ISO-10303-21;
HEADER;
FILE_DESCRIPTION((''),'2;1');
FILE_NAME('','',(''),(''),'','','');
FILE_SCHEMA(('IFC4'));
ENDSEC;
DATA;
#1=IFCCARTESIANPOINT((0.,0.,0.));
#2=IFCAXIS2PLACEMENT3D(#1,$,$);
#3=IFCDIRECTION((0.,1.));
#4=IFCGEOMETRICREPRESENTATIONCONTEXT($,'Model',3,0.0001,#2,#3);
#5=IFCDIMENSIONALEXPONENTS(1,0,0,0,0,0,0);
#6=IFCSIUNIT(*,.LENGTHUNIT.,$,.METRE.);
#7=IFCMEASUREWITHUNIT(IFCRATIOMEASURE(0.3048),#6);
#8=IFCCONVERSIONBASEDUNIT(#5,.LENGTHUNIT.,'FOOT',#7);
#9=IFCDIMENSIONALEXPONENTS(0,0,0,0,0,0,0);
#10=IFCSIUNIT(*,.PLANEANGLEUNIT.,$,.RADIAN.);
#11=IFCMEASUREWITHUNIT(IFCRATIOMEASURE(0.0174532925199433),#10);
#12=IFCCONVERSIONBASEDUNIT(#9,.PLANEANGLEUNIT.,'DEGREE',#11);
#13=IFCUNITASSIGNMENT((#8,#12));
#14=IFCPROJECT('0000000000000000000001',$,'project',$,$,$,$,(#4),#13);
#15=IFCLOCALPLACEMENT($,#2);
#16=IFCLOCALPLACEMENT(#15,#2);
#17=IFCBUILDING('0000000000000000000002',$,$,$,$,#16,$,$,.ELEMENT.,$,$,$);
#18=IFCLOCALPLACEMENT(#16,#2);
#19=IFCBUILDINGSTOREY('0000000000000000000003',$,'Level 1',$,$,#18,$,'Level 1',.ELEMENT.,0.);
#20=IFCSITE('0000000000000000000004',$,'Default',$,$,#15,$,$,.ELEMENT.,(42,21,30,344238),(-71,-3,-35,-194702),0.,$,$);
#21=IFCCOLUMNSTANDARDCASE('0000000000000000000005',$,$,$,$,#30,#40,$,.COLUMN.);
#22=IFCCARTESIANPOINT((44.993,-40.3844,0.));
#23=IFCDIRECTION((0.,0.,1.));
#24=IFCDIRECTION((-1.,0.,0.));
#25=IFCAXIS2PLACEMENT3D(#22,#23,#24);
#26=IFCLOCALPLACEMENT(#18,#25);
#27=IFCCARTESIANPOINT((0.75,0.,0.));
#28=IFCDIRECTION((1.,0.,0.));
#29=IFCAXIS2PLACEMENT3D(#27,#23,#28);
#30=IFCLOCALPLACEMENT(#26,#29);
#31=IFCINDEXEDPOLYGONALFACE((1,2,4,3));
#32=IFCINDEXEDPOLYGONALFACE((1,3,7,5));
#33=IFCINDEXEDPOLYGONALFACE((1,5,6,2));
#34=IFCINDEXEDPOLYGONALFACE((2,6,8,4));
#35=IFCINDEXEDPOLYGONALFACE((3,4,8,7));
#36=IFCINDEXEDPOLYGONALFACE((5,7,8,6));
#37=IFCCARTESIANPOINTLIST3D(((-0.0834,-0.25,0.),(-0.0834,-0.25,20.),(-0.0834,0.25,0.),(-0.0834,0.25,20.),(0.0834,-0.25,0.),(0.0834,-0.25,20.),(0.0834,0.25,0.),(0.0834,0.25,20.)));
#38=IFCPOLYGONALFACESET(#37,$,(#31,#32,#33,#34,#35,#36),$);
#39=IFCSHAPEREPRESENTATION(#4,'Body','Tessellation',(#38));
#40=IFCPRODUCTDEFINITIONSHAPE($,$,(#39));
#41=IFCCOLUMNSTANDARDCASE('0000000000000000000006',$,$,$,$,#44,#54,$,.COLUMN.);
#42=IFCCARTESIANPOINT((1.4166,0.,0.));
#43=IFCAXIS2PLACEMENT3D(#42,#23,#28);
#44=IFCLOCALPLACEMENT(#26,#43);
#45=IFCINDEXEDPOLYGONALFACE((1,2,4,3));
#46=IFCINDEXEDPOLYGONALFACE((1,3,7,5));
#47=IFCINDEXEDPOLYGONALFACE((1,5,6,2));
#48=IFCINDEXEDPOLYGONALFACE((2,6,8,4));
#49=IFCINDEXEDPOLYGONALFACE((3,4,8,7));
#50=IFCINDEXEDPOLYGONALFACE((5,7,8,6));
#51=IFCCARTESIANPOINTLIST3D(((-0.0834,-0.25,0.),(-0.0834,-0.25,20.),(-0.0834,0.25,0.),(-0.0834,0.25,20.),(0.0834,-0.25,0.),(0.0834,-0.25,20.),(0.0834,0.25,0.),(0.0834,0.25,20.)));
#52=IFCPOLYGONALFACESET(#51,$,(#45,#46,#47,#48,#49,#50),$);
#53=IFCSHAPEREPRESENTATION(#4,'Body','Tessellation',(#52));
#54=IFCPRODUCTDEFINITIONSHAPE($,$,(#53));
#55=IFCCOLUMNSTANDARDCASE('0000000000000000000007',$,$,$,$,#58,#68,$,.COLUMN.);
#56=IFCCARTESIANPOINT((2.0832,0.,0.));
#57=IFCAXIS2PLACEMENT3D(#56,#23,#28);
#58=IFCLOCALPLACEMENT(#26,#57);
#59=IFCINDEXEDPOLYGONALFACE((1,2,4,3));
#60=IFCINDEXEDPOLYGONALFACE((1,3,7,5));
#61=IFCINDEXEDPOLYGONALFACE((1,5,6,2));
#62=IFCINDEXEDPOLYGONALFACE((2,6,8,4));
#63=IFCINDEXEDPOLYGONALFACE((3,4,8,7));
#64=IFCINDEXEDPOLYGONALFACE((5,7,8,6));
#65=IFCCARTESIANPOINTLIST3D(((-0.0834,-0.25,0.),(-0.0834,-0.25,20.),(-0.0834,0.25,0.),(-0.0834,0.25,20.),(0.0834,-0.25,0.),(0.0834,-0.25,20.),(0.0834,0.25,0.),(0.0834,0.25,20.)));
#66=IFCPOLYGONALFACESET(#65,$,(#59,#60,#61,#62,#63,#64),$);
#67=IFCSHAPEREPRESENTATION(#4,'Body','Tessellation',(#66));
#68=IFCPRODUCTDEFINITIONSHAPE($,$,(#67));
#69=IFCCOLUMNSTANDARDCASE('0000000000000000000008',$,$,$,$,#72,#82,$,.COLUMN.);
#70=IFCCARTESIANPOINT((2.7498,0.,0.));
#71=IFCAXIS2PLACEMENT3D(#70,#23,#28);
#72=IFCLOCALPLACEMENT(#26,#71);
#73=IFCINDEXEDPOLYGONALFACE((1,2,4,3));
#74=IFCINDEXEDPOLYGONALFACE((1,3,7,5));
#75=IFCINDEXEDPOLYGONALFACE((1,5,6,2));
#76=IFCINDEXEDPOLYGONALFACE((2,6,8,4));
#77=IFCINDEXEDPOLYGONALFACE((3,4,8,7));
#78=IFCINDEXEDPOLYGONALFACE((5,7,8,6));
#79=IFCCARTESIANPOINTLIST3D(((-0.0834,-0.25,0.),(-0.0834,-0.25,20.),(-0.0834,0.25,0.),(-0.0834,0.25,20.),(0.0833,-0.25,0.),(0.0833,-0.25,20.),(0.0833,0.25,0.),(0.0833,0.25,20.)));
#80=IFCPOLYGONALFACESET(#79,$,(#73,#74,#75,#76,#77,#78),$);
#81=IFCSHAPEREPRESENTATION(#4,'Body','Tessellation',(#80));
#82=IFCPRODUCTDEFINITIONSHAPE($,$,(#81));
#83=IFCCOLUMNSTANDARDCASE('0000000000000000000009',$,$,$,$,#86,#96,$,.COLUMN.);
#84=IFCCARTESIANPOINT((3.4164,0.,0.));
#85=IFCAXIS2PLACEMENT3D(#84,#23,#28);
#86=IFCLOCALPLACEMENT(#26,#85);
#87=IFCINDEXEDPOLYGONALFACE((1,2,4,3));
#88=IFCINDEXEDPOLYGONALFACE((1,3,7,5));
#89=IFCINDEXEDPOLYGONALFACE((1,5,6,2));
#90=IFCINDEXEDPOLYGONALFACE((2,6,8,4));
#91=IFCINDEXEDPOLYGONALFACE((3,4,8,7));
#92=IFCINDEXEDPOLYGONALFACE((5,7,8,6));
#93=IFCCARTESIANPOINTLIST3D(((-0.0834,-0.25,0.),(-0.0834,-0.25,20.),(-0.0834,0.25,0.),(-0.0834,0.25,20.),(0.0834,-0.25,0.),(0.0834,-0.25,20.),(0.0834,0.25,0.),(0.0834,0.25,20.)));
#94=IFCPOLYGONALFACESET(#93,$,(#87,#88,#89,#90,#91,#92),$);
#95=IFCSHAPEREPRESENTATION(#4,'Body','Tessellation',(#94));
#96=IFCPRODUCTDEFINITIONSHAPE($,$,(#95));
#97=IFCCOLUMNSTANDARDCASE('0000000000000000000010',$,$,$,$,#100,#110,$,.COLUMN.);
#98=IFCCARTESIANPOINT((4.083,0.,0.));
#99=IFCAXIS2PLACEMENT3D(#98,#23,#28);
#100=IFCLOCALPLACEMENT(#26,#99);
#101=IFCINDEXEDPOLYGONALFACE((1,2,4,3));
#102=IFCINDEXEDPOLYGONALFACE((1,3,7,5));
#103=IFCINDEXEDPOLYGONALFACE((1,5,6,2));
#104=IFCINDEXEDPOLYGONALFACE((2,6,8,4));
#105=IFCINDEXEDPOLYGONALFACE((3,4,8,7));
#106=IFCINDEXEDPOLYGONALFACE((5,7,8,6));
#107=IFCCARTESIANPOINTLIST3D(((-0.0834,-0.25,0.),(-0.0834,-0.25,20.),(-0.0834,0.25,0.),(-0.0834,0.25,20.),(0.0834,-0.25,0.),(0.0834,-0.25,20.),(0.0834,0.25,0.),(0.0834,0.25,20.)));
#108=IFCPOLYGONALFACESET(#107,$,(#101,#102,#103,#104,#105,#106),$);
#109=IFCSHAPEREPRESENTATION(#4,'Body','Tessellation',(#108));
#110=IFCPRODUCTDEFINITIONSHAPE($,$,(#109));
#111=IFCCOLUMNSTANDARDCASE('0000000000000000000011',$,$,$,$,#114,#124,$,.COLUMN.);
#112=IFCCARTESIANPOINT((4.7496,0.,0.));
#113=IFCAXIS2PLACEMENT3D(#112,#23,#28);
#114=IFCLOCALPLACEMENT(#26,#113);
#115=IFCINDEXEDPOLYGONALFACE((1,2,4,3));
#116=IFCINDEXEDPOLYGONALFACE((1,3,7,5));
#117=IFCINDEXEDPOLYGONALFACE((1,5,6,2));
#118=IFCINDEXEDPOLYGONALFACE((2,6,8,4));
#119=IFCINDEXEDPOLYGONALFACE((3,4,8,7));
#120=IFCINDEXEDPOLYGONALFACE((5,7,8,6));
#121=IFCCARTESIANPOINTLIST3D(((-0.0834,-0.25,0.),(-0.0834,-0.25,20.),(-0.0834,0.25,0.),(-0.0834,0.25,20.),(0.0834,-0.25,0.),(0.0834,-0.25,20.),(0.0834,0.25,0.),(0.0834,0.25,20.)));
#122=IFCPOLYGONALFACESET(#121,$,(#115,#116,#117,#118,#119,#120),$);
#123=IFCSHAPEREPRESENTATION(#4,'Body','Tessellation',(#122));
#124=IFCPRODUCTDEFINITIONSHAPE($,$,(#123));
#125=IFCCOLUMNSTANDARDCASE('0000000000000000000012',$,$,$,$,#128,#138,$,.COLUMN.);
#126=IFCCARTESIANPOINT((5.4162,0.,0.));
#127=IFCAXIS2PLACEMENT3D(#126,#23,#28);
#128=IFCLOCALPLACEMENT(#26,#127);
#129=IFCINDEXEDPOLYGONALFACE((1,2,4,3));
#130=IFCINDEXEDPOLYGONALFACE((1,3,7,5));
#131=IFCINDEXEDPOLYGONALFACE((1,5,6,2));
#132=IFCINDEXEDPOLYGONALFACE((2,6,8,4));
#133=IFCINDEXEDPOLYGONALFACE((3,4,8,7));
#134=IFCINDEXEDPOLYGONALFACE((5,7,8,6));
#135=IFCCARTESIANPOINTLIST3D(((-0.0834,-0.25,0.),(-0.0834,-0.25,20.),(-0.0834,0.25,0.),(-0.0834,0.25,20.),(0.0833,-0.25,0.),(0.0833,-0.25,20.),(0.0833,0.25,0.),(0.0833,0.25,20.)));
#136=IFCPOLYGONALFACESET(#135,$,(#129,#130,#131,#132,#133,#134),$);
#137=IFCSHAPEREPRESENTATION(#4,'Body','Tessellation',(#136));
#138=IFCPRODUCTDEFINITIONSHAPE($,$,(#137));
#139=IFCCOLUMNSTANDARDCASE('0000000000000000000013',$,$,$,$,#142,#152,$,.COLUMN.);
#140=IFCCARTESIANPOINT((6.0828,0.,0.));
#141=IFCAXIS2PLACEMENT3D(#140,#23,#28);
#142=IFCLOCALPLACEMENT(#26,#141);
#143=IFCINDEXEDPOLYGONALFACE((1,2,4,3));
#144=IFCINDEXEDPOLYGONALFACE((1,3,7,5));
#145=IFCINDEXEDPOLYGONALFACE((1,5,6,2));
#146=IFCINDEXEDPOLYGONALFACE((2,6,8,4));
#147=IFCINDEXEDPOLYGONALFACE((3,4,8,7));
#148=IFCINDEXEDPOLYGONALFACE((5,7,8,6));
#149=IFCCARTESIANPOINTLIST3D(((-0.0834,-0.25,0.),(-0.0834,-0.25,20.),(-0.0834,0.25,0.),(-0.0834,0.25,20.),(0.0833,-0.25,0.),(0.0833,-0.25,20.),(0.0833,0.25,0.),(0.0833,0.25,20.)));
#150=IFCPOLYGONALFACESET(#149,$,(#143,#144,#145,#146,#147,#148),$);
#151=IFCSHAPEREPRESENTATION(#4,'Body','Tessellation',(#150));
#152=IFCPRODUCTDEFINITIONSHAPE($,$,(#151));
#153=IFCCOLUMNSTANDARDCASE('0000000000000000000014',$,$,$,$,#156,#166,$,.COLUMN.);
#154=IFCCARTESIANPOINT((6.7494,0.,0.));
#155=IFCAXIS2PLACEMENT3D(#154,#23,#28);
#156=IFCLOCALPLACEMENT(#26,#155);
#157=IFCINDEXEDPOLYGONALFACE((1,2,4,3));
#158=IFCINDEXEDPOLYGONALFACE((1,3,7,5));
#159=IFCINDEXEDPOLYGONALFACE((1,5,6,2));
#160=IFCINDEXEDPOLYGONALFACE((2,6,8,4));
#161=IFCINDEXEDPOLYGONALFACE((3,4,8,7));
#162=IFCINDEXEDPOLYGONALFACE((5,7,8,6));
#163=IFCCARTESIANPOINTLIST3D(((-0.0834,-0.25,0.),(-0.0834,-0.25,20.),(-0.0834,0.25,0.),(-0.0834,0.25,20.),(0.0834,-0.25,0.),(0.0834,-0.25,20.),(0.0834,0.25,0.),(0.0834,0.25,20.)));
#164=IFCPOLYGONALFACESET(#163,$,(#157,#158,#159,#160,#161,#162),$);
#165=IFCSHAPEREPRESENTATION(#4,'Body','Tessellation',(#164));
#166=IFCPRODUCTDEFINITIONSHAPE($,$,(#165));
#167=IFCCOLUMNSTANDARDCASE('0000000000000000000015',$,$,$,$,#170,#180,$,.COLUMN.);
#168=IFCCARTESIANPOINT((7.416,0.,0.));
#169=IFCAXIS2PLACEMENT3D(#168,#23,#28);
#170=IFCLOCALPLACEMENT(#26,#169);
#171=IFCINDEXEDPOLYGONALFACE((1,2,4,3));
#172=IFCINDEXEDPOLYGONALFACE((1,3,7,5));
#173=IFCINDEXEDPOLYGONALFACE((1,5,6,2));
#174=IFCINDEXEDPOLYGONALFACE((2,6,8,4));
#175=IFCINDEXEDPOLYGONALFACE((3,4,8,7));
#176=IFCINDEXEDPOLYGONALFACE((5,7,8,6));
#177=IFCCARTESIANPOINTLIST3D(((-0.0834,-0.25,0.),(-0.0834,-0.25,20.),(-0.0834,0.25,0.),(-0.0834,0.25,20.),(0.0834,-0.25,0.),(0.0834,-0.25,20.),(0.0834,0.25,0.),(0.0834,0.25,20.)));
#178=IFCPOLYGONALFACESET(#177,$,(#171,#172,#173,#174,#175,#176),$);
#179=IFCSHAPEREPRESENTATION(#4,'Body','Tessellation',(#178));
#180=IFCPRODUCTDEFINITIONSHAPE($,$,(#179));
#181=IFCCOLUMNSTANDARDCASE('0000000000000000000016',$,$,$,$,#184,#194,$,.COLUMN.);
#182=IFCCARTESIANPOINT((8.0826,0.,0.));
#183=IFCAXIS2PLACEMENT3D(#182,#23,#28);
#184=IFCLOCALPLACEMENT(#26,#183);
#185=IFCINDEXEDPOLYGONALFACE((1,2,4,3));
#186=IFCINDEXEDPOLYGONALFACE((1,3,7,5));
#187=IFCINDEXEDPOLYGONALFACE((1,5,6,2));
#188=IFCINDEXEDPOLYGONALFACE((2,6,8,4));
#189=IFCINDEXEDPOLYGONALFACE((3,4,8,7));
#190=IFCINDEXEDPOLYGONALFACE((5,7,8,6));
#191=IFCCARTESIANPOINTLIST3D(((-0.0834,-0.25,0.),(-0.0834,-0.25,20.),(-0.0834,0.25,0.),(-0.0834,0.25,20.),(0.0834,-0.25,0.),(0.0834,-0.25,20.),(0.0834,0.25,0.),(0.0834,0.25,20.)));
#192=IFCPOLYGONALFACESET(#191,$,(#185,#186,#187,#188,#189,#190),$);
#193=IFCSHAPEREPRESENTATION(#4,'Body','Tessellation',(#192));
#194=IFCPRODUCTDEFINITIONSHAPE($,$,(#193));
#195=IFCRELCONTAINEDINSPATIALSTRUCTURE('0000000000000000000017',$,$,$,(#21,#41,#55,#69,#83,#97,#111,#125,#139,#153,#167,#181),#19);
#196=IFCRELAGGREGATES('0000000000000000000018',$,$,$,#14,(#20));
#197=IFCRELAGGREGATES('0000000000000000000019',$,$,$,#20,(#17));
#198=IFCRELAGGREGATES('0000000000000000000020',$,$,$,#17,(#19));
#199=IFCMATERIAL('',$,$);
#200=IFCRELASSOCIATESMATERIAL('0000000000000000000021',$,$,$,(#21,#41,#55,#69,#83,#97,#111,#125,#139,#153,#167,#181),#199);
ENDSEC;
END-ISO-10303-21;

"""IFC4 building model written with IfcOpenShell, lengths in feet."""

from ifc_helpers import new_model, entity, si_unit, converted_unit, direction, frame, origin, place, context, project, spatial, rectangle, extrude, material, element, save


model = new_model("IFC4")

# Units and contexts
model_context = context("Model", 3, precision=0.0001, world=origin(), true_north=direction((0.0, 1.0)))
ifc_project = project(units=[converted_unit("LENGTHUNIT", "FOOT", entity("IfcRatioMeasure", 0.3048), si_unit("LENGTHUNIT", "METRE"), dimensions=[1, 0, 0, 0, 0, 0, 0]), converted_unit("PLANEANGLEUNIT", "DEGREE", entity("IfcRatioMeasure", 0.0174532925199433), si_unit("PLANEANGLEUNIT", "RADIAN"), dimensions=[0, 0, 0, 0, 0, 0, 0])], contexts=[model_context])

# Site, building, storey
site_placement = place(None, origin())
site = spatial("IfcSite", under=ifc_project, at=site_placement, Name="Default", CompositionType="ELEMENT", RefLatitude=(42, 21, 30, 344238), RefLongitude=(-71, -3, -35, -194702), RefElevation=0.0)
building_placement = place(site_placement, origin())
building = spatial("IfcBuilding", under=site, at=building_placement, CompositionType="ELEMENT")
storey_placement = place(building_placement, origin())
storey = spatial("IfcBuildingStorey", under=building, at=storey_placement, Name="Level 1", LongName="Level 1", CompositionType="ELEMENT", Elevation=0.0)

# Columns
ifc_material_1 = material(Name="")
wall_placement = place(storey_placement, frame((44.993, -40.3844, 0.0), z_axis=(0.0, 0.0, 1.0), x_axis=(-1.0, 0.0, 0.0)))
for number, where, z_axis, x_axis in (
    (1, (0.75, 0.0, 0.0), (0.0, 0.0, 1.0), (1.0, 0.0, 0.0)),
    (2, (1.4166, 0.0, 0.0), (0.0, 0.0, 1.0), (1.0, 0.0, 0.0)),
    (3, (2.0832, 0.0, 0.0), (0.0, 0.0, 1.0), (1.0, 0.0, 0.0)),
    (4, (2.7498, 0.0, 0.0), (0.0, 0.0, 1.0), (1.0, 0.0, 0.0)),
    (5, (3.4164, 0.0, 0.0), (0.0, 0.0, 1.0), (1.0, 0.0, 0.0)),
    (6, (4.083, 0.0, 0.0), (0.0, 0.0, 1.0), (1.0, 0.0, 0.0)),
    (7, (4.7496, 0.0, 0.0), (0.0, 0.0, 1.0), (1.0, 0.0, 0.0)),
    (8, (5.4162, 0.0, 0.0), (0.0, 0.0, 1.0), (1.0, 0.0, 0.0)),
    (9, (6.0828, 0.0, 0.0), (0.0, 0.0, 1.0), (1.0, 0.0, 0.0)),
    (10, (6.7494, 0.0, 0.0), (0.0, 0.0, 1.0), (1.0, 0.0, 0.0)),
    (11, (7.416, 0.0, 0.0), (0.0, 0.0, 1.0), (1.0, 0.0, 0.0)),
    (12, (8.0826, 0.0, 0.0), (0.0, 0.0, 1.0), (1.0, 0.0, 0.0)),
):
    element("IfcColumnStandardCase", number, at=place(wall_placement, frame(where, z_axis=z_axis, x_axis=x_axis)), inside=storey, material=ifc_material_1, PredefinedType="COLUMN", context=model_context, shape_type="SweptSolid", body=[
        extrude(rectangle(XDim=0.1667, YDim=0.5), origin(), (0.0, 0.0, 1.0), 20.0),
    ])

save(model, "model.ifc")
